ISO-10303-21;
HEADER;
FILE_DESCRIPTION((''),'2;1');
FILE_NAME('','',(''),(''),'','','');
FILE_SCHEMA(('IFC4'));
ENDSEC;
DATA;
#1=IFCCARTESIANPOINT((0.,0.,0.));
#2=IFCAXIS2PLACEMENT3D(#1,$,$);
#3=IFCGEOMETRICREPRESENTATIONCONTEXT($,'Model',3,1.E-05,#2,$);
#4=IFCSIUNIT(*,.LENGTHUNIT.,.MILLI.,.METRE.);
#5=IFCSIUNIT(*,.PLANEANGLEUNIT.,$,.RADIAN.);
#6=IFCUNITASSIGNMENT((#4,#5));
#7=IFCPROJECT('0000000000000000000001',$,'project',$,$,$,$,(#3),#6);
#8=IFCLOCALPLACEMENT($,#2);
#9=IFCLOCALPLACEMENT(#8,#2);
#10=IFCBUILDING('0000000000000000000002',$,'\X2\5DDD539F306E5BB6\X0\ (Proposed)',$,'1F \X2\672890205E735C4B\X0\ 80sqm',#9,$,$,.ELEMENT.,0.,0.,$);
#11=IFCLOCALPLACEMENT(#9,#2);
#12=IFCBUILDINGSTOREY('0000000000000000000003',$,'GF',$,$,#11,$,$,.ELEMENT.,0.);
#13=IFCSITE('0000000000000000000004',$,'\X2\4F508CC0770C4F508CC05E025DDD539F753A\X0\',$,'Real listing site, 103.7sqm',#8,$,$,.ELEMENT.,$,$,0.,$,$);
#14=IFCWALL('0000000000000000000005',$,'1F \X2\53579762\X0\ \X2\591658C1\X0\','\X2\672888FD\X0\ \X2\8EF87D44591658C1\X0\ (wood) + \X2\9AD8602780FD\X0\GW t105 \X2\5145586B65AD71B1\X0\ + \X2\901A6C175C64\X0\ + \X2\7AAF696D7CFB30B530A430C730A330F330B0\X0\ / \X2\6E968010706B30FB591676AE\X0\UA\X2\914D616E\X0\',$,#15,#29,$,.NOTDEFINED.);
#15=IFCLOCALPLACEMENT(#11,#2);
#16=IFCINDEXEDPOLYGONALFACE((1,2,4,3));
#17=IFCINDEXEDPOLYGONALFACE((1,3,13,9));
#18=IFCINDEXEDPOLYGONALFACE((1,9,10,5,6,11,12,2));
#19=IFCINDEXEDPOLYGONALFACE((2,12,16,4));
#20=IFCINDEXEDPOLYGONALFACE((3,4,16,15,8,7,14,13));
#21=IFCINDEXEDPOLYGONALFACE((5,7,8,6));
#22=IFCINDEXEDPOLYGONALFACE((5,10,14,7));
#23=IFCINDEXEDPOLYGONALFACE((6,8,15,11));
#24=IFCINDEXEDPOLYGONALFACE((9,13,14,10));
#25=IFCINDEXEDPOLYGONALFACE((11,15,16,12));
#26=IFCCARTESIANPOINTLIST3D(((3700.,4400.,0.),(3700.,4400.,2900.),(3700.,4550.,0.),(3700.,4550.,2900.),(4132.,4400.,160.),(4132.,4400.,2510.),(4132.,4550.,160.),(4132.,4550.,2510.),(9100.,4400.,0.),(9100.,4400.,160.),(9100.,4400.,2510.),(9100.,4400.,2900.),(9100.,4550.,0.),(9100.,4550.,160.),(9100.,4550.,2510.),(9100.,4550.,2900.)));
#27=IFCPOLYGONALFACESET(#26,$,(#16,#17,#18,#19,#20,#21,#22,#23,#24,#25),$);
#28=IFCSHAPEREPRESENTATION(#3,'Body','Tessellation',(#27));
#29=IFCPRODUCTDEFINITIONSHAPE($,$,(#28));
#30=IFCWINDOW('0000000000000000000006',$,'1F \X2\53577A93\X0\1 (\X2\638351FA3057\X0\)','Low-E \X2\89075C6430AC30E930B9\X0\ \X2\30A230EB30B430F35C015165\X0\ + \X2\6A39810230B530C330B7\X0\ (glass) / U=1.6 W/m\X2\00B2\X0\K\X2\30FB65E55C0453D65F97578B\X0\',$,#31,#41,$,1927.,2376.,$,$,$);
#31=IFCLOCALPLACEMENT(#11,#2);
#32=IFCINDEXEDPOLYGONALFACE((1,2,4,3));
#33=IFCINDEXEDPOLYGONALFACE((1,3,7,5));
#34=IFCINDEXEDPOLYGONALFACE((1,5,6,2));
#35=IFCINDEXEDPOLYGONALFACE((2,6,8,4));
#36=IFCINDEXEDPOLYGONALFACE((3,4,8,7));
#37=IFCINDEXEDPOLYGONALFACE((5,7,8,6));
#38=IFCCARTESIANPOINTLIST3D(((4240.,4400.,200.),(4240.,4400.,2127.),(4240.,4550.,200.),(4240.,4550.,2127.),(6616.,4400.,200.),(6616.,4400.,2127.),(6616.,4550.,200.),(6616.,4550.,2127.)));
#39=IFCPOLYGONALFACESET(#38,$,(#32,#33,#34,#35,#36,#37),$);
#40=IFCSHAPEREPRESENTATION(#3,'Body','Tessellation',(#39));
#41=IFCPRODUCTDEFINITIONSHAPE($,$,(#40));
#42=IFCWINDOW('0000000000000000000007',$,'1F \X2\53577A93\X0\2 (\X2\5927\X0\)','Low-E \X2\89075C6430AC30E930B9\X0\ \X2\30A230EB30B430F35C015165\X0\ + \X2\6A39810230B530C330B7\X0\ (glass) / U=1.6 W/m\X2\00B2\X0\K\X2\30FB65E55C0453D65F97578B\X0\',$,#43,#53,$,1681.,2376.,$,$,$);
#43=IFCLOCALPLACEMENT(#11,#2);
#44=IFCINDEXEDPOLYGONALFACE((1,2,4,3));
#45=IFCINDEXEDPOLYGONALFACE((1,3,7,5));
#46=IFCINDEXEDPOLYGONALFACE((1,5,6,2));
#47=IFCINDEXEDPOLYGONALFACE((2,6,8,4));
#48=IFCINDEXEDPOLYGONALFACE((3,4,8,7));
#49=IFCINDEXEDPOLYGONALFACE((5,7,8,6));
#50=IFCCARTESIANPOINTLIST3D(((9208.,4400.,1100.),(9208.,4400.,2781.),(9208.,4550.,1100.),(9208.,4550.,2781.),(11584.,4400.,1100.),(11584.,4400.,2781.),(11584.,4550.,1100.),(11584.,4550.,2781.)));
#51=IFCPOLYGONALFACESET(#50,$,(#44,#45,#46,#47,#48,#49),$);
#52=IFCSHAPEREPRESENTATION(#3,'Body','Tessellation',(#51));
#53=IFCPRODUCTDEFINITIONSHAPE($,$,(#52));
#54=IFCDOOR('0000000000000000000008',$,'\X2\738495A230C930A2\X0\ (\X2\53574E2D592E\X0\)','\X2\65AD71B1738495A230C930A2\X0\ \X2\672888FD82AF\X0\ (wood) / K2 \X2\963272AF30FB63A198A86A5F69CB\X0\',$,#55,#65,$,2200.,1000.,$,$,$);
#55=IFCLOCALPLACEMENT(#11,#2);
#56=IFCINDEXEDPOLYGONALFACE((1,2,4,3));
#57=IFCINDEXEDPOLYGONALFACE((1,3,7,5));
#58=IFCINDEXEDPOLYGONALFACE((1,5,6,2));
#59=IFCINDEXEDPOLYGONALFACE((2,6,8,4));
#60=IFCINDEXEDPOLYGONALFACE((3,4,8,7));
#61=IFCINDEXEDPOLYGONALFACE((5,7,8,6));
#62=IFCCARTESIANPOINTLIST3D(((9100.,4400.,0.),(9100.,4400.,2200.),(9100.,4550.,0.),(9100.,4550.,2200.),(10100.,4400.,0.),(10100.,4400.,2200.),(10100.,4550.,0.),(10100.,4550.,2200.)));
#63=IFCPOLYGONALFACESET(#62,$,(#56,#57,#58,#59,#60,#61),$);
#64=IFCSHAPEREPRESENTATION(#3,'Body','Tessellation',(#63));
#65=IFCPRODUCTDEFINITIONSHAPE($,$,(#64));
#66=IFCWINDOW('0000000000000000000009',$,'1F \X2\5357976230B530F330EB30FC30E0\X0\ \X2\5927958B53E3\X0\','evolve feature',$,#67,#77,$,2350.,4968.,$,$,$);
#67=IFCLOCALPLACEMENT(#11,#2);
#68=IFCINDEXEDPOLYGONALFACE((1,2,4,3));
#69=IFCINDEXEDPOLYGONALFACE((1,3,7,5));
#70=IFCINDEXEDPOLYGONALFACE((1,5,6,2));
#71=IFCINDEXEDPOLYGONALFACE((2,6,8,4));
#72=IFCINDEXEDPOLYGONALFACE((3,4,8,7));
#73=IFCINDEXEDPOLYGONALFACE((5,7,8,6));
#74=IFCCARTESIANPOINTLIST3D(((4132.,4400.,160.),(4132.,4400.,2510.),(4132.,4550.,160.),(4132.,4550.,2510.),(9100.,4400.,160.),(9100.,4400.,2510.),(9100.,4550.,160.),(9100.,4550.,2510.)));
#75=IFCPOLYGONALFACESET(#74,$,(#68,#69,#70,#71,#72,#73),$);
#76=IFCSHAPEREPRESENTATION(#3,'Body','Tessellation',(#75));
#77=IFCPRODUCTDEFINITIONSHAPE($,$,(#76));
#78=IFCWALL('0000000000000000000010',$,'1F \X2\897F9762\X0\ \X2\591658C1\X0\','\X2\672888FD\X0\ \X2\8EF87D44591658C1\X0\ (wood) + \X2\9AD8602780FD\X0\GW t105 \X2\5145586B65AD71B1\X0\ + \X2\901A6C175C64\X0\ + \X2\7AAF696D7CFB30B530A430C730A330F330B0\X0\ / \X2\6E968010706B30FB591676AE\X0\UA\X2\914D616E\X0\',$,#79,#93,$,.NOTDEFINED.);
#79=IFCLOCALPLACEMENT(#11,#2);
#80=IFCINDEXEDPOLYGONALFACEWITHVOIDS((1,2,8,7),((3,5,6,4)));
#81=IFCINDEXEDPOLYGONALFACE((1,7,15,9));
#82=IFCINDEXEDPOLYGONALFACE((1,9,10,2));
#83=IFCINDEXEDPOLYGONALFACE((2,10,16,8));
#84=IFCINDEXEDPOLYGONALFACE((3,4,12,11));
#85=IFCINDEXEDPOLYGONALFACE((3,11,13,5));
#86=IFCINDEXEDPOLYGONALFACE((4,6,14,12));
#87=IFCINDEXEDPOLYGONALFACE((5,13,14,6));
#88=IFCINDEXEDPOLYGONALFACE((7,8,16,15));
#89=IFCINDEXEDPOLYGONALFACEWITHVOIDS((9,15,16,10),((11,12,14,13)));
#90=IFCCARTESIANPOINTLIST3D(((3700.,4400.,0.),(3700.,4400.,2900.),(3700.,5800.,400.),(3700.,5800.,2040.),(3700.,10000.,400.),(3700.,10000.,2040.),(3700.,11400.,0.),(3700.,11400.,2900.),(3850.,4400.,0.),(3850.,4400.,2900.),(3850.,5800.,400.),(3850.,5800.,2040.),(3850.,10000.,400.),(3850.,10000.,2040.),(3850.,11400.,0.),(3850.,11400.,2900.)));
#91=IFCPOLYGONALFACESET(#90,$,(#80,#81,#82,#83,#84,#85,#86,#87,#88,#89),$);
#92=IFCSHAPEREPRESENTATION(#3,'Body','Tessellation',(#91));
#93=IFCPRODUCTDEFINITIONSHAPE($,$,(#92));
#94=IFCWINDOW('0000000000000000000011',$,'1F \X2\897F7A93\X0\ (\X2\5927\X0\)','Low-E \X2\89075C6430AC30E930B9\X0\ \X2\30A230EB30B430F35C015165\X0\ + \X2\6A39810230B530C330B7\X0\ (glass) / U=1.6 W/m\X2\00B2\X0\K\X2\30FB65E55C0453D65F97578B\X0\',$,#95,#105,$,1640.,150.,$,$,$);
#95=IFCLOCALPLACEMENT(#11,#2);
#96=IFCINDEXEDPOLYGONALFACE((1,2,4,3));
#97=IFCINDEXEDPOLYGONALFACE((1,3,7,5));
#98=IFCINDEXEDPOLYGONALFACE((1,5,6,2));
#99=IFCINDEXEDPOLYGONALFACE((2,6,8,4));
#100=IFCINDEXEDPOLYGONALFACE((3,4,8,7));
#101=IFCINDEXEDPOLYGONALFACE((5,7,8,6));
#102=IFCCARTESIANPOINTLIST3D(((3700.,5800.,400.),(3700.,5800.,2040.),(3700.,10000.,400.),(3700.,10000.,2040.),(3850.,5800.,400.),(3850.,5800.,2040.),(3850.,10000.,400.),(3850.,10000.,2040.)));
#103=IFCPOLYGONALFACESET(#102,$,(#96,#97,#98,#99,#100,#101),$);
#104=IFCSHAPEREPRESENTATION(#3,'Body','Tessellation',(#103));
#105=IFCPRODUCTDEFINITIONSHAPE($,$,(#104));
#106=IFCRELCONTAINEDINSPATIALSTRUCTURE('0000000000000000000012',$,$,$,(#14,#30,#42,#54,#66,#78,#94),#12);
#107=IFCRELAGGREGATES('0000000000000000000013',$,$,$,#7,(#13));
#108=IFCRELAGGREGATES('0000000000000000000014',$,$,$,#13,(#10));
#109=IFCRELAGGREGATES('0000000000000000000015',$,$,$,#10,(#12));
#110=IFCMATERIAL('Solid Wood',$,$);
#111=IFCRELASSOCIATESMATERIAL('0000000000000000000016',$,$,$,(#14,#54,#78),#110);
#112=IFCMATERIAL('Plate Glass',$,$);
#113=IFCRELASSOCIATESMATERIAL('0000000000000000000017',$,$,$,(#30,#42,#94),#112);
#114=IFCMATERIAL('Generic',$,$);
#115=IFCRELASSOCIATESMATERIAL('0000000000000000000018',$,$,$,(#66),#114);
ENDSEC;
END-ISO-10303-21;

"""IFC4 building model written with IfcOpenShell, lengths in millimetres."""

from ifc_helpers import new_model, si_unit, frame, frame_2d, origin, place, context, project, spatial, rectangle, extrude, material, element, fill, save


model = new_model("IFC4")

# Units and contexts
model_context = context("Model", 3, precision=1e-05, world=origin())
ifc_project = project(units=[si_unit("LENGTHUNIT", "METRE", prefix="MILLI"), si_unit("PLANEANGLEUNIT", "RADIAN")], contexts=[model_context])

# Site, building, storey
site_placement = place(None, origin())
site = spatial("IfcSite", under=ifc_project, at=site_placement, Name="佐賀県佐賀市川原町", ObjectType="Real listing site, 103.7sqm", CompositionType="ELEMENT", RefElevation=0.0)
building_placement = place(site_placement, origin())
building = spatial("IfcBuilding", under=site, at=building_placement, Name="川原の家 (Proposed)", ObjectType="1F 木造平屋 80sqm", CompositionType="ELEMENT", ElevationOfRefHeight=0.0, ElevationOfTerrain=0.0)
storey_placement = place(building_placement, origin())
storey = spatial("IfcBuildingStorey", under=building, at=storey_placement, Name="GF", CompositionType="ELEMENT", Elevation=0.0)

# Shared definitions
ifc_material_1 = material(Name="Solid Wood")
ifc_material_2 = material(Name="Generic")

# Wall, openings, windows, door
wall_1_placement = place(storey_placement, frame((1850.0, 2200.0, 0.0)))
wall_1 = element("IfcWall", 1, at=wall_1_placement, inside=storey, material=ifc_material_1, Name="1F 南面 外壁", Description="木製 軸組外壁 (wood) + 高性能GW t105 充填断熱 + 通気層 + 窯業系サイディング / 準耐火・外皮UA配慮", PredefinedType="NOTDEFINED", context=model_context, shape_type="SweptSolid", body=[
    extrude(rectangle(XDim=5400.0, YDim=150.0, at=frame_2d((2700.0, 75.0))), frame((1850.0, 2200.0, 0.0)), (0.0, 0.0, 1.0), 2900.0),
])
opening_1_placement = place(storey_placement, frame((2120.0, 2200.0, 100.0)))
opening_1 = element("IfcOpeningElement", 2, at=opening_1_placement, cuts=wall_1, PredefinedType="NOTDEFINED", context=model_context, shape_type="SweptSolid", body=[
    extrude(rectangle(XDim=2376.0, YDim=150.0, at=frame_2d((1188.0, 75.0))), frame((2120.0, 2200.0, 100.0)), (0.0, 0.0, 1.0), 1927.0),
])
opening_2_placement = place(storey_placement, frame((4604.0, 2200.0, 550.0)))
opening_2 = element("IfcOpeningElement", 3, at=opening_2_placement, cuts=wall_1, PredefinedType="NOTDEFINED", context=model_context, shape_type="SweptSolid", body=[
    extrude(rectangle(XDim=2376.0, YDim=150.0, at=frame_2d((1188.0, 75.0))), frame((4604.0, 2200.0, 550.0)), (0.0, 0.0, 1.0), 1681.0),
])
opening_3_placement = place(storey_placement, frame((4550.0, 2200.0, 0.0)))
opening_3 = element("IfcOpeningElement", 4, at=opening_3_placement, cuts=wall_1, PredefinedType="NOTDEFINED", context=model_context, shape_type="SweptSolid", body=[
    extrude(rectangle(XDim=1000.0, YDim=150.0, at=frame_2d((500.0, 75.0))), frame((4550.0, 2200.0, 0.0)), (0.0, 0.0, 1.0), 2200.0),
])
opening_4_placement = place(storey_placement, frame((2066.0, 2200.0, 80.0)))
opening_4 = element("IfcOpeningElement", 5, at=opening_4_placement, cuts=wall_1, PredefinedType="NOTDEFINED", context=model_context, shape_type="SweptSolid", body=[
    extrude(rectangle(XDim=4968.0, YDim=150.0, at=frame_2d((2484.0, 75.0))), frame((2066.0, 2200.0, 80.0)), (0.0, 0.0, 1.0), 2350.0),
])
ifc_material_3 = material(Name="Plate Glass")
window_1_placement = place(storey_placement, frame((2120.0, 2200.0, 100.0)))
window_1 = element("IfcWindow", 6, at=window_1_placement, inside=storey, material=ifc_material_3, Name="1F 南窓1 (掃出し)", Description="Low-E 複層ガラス アルゴン封入 + 樹脂サッシ (glass) / U=1.6 W/m²K・日射取得型", OverallHeight=1927.0, OverallWidth=2376.0, context=model_context, shape_type="SweptSolid", body=[
    extrude(rectangle(XDim=2376.0, YDim=150.0, at=frame_2d((1188.0, 75.0))), frame((2120.0, 2200.0, 100.0)), (0.0, 0.0, 1.0), 1927.0),
])
fill(opening_1, window_1)
window_2_placement = place(storey_placement, frame((4604.0, 2200.0, 550.0)))
window_2 = element("IfcWindow", 7, at=window_2_placement, inside=storey, material=ifc_material_3, Name="1F 南窓2 (大)", Description="Low-E 複層ガラス アルゴン封入 + 樹脂サッシ (glass) / U=1.6 W/m²K・日射取得型", OverallHeight=1681.0, OverallWidth=2376.0, context=model_context, shape_type="SweptSolid", body=[
    extrude(rectangle(XDim=2376.0, YDim=150.0, at=frame_2d((1188.0, 75.0))), frame((4604.0, 2200.0, 550.0)), (0.0, 0.0, 1.0), 1681.0),
])
fill(opening_2, window_2)
door_placement = place(storey_placement, frame((4550.0, 2200.0, 0.0)))
door = element("IfcDoor", 8, at=door_placement, inside=storey, material=ifc_material_1, Name="玄関ドア (南中央)", Description="断熱玄関ドア 木製芯 (wood) / K2 防犯・採風機構", OverallHeight=2200.0, OverallWidth=1000.0, context=model_context, shape_type="SweptSolid", body=[
    extrude(rectangle(XDim=1000.0, YDim=150.0, at=frame_2d((500.0, 75.0))), frame((4550.0, 2200.0, 0.0)), (0.0, 0.0, 1.0), 2200.0),
])
fill(opening_3, door)
window_3_placement = place(storey_placement, frame((2066.0, 2200.0, 80.0)))
window_3 = element("IfcWindow", 9, at=window_3_placement, inside=storey, material=ifc_material_2, Name="1F 南面サンルーム 大開口", Description="evolve feature", OverallHeight=2350.0, OverallWidth=4968.0, context=model_context, shape_type="SweptSolid", body=[
    extrude(rectangle(XDim=4968.0, YDim=150.0, at=frame_2d((2484.0, 75.0))), frame((2066.0, 2200.0, 80.0)), (0.0, 0.0, 1.0), 2350.0),
])
fill(opening_4, window_3)

# Wall, opening, window
wall_2_placement = place(storey_placement, frame((1850.0, 2200.0, 0.0)))
wall_2 = element("IfcWall", 10, at=wall_2_placement, inside=storey, material=ifc_material_1, Name="1F 西面 外壁", Description="木製 軸組外壁 (wood) + 高性能GW t105 充填断熱 + 通気層 + 窯業系サイディング / 準耐火・外皮UA配慮", PredefinedType="NOTDEFINED", context=model_context, shape_type="SweptSolid", body=[
    extrude(rectangle(XDim=150.0, YDim=7000.0, at=frame_2d((75.0, 3500.0))), frame((1850.0, 2200.0, 0.0)), (0.0, 0.0, 1.0), 2900.0),
])
opening_5_placement = place(storey_placement, frame((1850.0, 2900.0, 200.0)))
opening_5 = element("IfcOpeningElement", 11, at=opening_5_placement, cuts=wall_2, PredefinedType="NOTDEFINED", context=model_context, shape_type="SweptSolid", body=[
    extrude(rectangle(XDim=150.0, YDim=4200.0, at=frame_2d((75.0, 2100.0))), frame((1850.0, 2900.0, 200.0)), (0.0, 0.0, 1.0), 1640.0),
])
window_4_placement = place(storey_placement, frame((1850.0, 2900.0, 200.0)))
window_4 = element("IfcWindow", 12, at=window_4_placement, inside=storey, material=ifc_material_3, Name="1F 西窓 (大)", Description="Low-E 複層ガラス アルゴン封入 + 樹脂サッシ (glass) / U=1.6 W/m²K・日射取得型", OverallHeight=1640.0, OverallWidth=150.0, context=model_context, shape_type="SweptSolid", body=[
    extrude(rectangle(XDim=150.0, YDim=4200.0, at=frame_2d((75.0, 2100.0))), frame((1850.0, 2900.0, 200.0)), (0.0, 0.0, 1.0), 1640.0),
])
fill(opening_5, window_4)

save(model, "model.ifc")
